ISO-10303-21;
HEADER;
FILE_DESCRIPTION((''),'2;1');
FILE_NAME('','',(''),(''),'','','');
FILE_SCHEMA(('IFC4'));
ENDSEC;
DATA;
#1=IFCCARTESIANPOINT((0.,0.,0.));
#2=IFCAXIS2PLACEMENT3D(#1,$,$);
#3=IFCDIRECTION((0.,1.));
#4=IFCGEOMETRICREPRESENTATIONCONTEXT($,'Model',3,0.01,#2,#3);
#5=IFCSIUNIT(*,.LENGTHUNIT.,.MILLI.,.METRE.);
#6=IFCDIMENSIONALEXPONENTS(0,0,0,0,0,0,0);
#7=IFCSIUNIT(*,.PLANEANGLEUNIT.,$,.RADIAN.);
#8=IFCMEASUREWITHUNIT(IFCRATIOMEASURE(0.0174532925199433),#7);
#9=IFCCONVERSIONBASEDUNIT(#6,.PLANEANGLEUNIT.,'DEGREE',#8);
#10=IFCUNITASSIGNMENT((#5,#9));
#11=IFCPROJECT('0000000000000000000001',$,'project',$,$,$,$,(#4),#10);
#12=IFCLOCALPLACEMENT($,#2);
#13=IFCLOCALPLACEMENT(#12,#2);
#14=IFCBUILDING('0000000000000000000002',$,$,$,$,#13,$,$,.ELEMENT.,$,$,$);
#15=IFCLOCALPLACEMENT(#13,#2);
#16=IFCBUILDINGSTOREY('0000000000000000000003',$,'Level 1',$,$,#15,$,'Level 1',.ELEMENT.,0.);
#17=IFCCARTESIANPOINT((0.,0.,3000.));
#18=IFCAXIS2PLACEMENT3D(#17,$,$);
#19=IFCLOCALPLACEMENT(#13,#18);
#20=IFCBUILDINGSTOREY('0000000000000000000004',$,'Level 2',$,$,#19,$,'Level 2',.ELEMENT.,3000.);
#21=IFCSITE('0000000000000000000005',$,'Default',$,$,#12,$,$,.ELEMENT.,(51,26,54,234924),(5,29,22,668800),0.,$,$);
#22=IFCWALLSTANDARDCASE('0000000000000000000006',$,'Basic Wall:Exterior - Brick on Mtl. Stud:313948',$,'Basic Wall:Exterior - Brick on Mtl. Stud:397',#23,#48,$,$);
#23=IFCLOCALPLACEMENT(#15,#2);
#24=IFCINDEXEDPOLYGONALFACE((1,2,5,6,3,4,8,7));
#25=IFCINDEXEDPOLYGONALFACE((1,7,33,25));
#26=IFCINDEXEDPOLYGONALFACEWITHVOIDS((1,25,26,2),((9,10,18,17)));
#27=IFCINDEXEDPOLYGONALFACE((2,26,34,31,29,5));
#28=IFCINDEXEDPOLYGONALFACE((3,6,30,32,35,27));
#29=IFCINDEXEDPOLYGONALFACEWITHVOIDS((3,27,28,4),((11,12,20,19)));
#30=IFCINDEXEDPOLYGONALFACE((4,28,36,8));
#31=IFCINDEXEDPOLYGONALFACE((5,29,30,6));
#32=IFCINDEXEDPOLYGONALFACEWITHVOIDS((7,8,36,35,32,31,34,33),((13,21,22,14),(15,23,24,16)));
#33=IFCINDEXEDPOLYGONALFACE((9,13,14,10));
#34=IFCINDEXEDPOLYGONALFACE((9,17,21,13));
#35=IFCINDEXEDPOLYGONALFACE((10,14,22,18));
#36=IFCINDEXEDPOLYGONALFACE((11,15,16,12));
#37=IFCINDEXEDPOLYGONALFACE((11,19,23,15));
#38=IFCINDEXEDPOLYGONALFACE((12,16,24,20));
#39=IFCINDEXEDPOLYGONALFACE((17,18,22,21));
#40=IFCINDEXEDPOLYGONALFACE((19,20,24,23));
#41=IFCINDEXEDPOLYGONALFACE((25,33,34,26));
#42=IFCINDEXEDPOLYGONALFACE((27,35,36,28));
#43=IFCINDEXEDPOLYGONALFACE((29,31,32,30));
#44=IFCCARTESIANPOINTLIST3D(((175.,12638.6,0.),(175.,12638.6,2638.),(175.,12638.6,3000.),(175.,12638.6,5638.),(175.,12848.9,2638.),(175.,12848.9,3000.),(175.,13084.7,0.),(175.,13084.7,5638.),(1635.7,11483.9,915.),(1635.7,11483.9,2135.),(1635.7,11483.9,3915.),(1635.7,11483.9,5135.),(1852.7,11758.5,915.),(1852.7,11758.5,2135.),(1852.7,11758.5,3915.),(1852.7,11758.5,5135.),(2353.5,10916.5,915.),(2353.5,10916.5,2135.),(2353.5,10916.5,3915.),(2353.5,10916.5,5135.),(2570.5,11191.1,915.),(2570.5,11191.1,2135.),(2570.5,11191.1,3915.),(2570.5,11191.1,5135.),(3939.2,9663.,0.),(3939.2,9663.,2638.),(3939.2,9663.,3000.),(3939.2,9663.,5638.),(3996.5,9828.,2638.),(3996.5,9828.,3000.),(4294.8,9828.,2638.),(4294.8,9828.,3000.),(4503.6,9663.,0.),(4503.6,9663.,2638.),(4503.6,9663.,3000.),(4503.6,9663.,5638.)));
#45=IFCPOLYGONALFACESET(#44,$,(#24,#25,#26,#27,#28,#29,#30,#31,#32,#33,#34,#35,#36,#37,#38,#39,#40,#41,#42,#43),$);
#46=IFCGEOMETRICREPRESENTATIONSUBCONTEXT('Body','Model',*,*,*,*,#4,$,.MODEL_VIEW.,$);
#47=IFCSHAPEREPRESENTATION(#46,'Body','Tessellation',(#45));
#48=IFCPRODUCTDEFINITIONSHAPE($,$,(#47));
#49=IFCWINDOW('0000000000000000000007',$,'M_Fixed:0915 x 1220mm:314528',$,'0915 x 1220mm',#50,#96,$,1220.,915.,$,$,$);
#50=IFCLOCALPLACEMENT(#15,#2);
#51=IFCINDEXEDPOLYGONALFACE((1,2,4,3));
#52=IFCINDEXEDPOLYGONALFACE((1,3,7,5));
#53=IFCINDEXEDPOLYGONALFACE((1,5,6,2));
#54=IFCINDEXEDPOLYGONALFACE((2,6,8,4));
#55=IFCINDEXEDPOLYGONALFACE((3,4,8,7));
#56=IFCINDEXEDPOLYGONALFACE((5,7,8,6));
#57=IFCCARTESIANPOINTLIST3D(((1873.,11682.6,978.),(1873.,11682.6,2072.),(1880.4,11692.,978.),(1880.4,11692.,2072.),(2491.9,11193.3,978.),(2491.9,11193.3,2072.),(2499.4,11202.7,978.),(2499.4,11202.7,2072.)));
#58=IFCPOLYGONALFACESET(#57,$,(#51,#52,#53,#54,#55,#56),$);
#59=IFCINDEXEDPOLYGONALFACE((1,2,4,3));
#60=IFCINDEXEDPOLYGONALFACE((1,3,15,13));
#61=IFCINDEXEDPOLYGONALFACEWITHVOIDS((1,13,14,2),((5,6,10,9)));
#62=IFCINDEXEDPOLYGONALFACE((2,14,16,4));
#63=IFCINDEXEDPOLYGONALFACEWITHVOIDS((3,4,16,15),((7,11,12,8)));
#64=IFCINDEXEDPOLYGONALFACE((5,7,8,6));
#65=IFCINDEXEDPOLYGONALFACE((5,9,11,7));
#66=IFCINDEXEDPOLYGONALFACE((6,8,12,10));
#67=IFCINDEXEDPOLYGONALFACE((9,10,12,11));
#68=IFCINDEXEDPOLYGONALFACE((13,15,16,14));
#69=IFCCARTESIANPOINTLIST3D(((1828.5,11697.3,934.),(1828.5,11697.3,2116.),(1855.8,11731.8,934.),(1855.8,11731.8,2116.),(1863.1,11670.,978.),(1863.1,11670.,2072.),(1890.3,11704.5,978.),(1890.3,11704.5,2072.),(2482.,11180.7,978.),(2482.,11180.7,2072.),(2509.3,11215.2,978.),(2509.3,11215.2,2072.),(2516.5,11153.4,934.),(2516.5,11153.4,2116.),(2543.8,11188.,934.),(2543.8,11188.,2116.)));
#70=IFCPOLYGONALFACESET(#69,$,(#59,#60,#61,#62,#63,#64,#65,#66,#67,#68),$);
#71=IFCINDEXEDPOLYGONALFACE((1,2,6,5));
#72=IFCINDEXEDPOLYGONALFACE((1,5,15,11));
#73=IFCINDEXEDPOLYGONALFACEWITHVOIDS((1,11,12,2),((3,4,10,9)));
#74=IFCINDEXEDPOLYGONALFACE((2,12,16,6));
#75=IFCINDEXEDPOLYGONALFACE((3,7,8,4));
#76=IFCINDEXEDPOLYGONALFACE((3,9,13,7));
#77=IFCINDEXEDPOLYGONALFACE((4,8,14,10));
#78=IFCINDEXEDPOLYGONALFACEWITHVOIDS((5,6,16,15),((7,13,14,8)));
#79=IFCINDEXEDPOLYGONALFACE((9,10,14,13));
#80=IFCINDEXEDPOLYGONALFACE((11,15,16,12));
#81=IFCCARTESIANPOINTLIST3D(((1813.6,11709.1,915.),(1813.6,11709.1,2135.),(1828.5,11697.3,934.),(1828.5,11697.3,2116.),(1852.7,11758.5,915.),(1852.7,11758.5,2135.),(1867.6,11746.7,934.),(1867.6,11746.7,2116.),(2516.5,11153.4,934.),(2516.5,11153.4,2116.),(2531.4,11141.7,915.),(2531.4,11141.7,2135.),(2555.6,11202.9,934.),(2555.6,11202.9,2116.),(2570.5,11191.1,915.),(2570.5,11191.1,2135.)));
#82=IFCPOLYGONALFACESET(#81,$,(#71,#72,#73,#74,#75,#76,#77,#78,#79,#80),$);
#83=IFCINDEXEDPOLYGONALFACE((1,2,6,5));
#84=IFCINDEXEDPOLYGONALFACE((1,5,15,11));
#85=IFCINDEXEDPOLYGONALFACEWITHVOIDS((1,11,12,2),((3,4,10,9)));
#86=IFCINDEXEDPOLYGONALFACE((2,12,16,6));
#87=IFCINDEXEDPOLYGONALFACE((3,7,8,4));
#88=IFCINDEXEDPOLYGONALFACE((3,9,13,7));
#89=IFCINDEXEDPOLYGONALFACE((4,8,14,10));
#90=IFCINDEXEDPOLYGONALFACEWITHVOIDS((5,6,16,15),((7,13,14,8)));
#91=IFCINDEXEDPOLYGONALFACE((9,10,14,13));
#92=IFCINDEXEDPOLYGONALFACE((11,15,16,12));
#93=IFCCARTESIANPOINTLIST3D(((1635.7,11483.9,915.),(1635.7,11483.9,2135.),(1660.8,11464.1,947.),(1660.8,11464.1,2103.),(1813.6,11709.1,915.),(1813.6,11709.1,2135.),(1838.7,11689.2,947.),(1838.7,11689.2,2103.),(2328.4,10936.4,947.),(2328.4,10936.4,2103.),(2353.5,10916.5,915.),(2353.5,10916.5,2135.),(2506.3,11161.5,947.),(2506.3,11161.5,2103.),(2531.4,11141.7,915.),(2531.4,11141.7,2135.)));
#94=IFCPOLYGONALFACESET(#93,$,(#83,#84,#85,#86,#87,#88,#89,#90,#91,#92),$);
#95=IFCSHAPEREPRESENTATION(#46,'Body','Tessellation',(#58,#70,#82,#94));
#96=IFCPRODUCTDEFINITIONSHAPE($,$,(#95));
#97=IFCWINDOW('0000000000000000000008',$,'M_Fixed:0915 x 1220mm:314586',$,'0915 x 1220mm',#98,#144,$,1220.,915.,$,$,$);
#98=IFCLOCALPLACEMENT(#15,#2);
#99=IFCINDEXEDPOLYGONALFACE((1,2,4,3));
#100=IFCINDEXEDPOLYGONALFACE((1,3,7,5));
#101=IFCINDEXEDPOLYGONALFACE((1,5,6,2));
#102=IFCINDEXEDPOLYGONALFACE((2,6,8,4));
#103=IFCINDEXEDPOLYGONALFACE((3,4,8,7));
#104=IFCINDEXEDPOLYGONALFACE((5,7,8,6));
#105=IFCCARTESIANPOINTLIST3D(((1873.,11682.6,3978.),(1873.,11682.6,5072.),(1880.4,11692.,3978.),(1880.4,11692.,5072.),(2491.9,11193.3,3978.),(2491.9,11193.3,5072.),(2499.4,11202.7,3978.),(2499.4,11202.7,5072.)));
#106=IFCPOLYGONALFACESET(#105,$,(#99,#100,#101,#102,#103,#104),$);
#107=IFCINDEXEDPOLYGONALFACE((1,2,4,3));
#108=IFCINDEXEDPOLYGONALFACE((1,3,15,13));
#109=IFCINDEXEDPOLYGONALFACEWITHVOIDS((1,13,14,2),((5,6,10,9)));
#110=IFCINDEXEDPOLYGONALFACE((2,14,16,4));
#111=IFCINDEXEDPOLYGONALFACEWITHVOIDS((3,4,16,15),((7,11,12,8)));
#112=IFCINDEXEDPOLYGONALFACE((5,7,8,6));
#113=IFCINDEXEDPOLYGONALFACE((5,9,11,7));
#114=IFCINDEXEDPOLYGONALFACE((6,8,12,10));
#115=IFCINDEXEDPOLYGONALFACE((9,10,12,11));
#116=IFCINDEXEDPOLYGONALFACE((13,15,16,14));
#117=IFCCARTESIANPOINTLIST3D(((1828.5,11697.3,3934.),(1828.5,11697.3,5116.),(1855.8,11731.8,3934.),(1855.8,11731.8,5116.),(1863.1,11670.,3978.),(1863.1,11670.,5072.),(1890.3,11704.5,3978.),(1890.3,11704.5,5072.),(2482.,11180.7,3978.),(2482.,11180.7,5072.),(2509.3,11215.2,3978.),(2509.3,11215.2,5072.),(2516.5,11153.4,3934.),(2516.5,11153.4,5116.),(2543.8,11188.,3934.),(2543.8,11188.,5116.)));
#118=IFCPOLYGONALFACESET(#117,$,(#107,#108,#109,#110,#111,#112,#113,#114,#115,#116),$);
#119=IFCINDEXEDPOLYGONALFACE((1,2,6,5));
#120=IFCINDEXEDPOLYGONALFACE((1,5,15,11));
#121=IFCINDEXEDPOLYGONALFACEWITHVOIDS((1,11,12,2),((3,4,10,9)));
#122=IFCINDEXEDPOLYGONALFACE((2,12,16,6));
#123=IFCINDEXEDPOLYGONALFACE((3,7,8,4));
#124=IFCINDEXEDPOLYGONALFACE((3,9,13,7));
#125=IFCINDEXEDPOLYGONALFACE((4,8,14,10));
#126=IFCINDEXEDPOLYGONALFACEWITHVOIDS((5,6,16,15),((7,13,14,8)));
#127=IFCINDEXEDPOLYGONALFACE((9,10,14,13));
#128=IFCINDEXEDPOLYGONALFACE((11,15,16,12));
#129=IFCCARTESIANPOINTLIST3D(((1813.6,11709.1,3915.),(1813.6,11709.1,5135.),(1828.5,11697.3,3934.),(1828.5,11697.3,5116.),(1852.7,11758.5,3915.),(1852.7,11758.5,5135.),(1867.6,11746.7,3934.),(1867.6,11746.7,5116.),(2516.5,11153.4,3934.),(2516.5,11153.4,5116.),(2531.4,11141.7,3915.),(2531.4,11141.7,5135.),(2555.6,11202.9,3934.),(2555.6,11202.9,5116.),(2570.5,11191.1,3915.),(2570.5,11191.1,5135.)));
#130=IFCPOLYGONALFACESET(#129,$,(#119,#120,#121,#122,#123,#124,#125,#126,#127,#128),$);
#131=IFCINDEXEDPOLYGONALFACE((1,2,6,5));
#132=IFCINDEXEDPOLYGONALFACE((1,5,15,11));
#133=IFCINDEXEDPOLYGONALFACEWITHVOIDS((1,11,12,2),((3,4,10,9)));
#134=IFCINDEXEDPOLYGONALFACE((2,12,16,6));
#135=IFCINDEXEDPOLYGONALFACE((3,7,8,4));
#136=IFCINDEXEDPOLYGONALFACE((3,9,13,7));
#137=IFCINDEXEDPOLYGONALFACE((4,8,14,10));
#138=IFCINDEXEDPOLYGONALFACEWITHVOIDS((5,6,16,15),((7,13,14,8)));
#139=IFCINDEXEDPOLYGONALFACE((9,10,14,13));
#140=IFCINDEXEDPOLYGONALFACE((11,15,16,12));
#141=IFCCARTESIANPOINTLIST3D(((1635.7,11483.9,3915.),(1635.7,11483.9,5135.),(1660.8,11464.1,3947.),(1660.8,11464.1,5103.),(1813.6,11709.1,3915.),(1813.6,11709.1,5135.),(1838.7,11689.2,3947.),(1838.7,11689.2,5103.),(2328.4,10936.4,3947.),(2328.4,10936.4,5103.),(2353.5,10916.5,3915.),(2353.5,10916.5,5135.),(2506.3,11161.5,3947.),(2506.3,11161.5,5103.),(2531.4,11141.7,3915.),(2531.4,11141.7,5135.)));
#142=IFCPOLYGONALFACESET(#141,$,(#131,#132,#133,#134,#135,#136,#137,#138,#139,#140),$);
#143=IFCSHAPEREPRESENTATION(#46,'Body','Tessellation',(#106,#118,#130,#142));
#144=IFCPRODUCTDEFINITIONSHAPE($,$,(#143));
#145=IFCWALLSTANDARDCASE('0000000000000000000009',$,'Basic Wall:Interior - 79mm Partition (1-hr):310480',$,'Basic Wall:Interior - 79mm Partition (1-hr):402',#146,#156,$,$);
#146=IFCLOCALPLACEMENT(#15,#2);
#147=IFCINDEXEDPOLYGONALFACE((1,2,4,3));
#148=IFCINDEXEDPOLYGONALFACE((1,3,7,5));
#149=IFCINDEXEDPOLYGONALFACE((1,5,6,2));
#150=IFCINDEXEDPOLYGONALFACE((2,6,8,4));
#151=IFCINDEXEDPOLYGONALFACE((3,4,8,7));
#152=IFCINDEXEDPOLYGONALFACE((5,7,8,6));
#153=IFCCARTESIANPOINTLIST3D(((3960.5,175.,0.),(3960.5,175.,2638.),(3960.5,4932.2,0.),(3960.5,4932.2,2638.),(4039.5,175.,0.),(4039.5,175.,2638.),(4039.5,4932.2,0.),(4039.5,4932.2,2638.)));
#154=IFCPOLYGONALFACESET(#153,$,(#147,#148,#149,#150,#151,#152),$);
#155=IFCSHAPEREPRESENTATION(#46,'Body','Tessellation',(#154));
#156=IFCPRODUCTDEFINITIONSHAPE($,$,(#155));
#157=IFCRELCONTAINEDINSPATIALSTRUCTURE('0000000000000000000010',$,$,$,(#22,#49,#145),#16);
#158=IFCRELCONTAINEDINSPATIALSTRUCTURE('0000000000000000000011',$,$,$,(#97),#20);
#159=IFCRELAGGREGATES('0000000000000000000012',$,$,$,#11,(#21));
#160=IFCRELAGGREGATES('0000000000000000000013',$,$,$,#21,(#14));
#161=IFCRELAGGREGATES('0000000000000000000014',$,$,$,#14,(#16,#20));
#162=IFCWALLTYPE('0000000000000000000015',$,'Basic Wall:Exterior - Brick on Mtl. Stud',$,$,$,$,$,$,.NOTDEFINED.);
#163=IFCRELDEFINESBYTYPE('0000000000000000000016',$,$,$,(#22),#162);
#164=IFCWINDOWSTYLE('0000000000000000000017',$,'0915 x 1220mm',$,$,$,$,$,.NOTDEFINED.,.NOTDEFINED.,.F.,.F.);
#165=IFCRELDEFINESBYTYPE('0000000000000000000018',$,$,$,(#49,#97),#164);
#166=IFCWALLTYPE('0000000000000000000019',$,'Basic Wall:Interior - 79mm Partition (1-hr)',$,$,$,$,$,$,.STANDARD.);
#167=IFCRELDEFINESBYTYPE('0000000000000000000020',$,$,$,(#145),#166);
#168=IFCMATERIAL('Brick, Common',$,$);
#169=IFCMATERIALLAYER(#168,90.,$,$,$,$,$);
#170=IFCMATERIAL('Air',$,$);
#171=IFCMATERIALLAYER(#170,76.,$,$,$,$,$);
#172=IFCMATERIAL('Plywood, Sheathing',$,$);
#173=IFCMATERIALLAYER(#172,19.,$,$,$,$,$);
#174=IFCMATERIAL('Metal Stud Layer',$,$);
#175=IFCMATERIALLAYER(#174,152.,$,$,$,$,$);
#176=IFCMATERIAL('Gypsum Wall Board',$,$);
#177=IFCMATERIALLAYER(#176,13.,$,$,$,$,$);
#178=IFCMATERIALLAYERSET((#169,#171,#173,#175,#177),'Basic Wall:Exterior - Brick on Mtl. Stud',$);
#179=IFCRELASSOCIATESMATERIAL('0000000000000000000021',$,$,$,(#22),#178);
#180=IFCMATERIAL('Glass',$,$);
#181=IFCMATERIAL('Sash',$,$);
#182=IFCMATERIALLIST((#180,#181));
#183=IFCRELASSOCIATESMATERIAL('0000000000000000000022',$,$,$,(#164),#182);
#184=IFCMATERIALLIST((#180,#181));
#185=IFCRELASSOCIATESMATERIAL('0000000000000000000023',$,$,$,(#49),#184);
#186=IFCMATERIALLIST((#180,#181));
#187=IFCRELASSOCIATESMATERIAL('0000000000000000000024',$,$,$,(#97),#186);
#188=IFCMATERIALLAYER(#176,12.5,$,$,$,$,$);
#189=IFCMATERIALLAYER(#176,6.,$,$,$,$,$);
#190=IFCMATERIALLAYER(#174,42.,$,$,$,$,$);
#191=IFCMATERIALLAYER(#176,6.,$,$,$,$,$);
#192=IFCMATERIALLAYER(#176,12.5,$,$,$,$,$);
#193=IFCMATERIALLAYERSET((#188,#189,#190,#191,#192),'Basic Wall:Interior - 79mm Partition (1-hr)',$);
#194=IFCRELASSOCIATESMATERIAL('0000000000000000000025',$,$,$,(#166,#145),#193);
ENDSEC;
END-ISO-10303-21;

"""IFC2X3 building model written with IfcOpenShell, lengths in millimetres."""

from ifc_helpers import new_model, entity, si_unit, converted_unit, direction, frame, frame_2d, origin, place, context, subcontext, project, spatial, polyline, rectangle, outline, extrude, clip, bounded_halfspace, source, transform, mapped, material, material_list, layer, layer_set, layer_usage, type_object, type_shapes, element, fill, save


model = new_model("IFC2X3")

# Units and contexts
model_context = context("Model", 3, precision=0.01, world=origin(), true_north=direction((0.0, 1.0)))
body_context = subcontext(model_context, "Body", "Model", "MODEL_VIEW")
ifc_project = project(units=[si_unit("LENGTHUNIT", "METRE", prefix="MILLI"), converted_unit("PLANEANGLEUNIT", "DEGREE", entity("IfcRatioMeasure", 0.0174532925199433), si_unit("PLANEANGLEUNIT", "RADIAN"), dimensions=[0, 0, 0, 0, 0, 0, 0])], contexts=[model_context])

# Site, building, storey
site_placement = place(None, origin())
site = spatial("IfcSite", under=ifc_project, at=site_placement, Name="Default", CompositionType="ELEMENT", RefLatitude=(51, 26, 54, 234924), RefLongitude=(5, 29, 22, 668800), RefElevation=0.0)
building_placement = place(site_placement, origin())
building = spatial("IfcBuilding", under=site, at=building_placement, CompositionType="ELEMENT")
storey_1_placement = place(building_placement, origin())
storey_1 = spatial("IfcBuildingStorey", under=building, at=storey_1_placement, Name="Level 1", LongName="Level 1", CompositionType="ELEMENT", Elevation=0.0)

# Wall, openings, window
ifc_material_1 = material(Name="Brick, Common")
ifc_layer_1 = layer(ifc_material_1, 90.0)
ifc_material_2 = material(Name="Air")
ifc_layer_2 = layer(ifc_material_2, 76.0)
ifc_material_3 = material(Name="Plywood, Sheathing")
ifc_layer_3 = layer(ifc_material_3, 19.0)
ifc_material_4 = material(Name="Metal Stud Layer")
ifc_layer_4 = layer(ifc_material_4, 152.0)
ifc_material_5 = material(Name="Gypsum Wall Board")
ifc_layer_5 = layer(ifc_material_5, 13.0)
ifc_layer_set_1 = layer_set([ifc_layer_1, ifc_layer_2, ifc_layer_3, ifc_layer_4, ifc_layer_5], Name="Basic Wall:Exterior - Brick on Mtl. Stud")
ifc_layer_usage_1 = layer_usage(ifc_layer_set_1, "AXIS2", "NEGATIVE", 175.0)
wall_type_1 = type_object("IfcWallType", Name="Basic Wall:Exterior - Brick on Mtl. Stud", PredefinedType="NOTDEFINED")
wall_1_placement = place(storey_1_placement, frame((66.5, 12947.5, 0.0), z_axis=(0.0, 0.0, 1.0), x_axis=(0.784491, -0.62014, 0.0)))
wall_1 = element("IfcWallStandardCase", 1, at=wall_1_placement, inside=storey_1, type_object=wall_type_1, material=ifc_layer_usage_1, Name="Basic Wall:Exterior - Brick on Mtl. Stud:313948", ObjectType="Basic Wall:Exterior - Brick on Mtl. Stud:397", context=body_context, shape_type="Clipping", body=[
    clip(extrude(outline(polyline([(5074.9, -175.0), (5517.7, 175.0), (4953.3, 175.0), (0.0, 175.0), (276.7, -175.0), (5074.9, -175.0)])), origin(), (0.0, 0.0, 1.0), 5638.0), bounded_halfspace(frame((4808.9, -175.0, 5638.0), z_axis=(0.0, 0.0, -1.0), x_axis=(0.784491, 0.62014, 0.0)), True, frame((4808.9, -175.0, 5638.0)), polyline([(0.0, 0.0), (266.1, 0.0), (708.8, 350.0), (442.8, 350.0), (208.7, 165.0), (-4662.6, 165.0), (-4532.2, 0.0), (0.0, 0.0)]))),
])
opening_1_placement = place(storey_1_placement, frame((66.5, 12947.5, 0.0), z_axis=(0.0, 0.0, 1.0), x_axis=(0.784491, -0.62014, 0.0)))
element("IfcOpeningElement", 2, at=opening_1_placement, cuts=wall_1, ObjectType="Opening", context=body_context, shape_type="SweptSolid", body=[
    extrude(outline(polyline([(-1447.5, -916.9), (-1656.2, -1081.9), (-1091.8, -1081.9), (2672.4, 1893.7), (2672.4, 2104.0), (-1149.2, -916.9), (-1447.5, -916.9)])), frame((3547.5, -3.3, 2638.0), z_axis=(0.0, 0.0, -1.0), x_axis=(-0.784491, -0.62014, 0.0)), (0.0, 0.0, -1.0), 362.0),
])
opening_2_placement = place(wall_1_placement, frame((2138.6, -175.0, 915.0)))
opening_2 = element("IfcOpeningElement", 3, at=opening_2_placement, cuts=wall_1, ObjectType="Opening", context=body_context, shape_type="SweptSolid", body=[
    extrude(rectangle(XDim=1220.0, YDim=915.0, at=frame_2d((610.0, 457.5), x_axis=(1.0, 0.0))), frame((0.0, 0.0, 0.0), z_axis=(0.0, 1.0, 0.0), x_axis=(0.0, 0.0, 1.0)), (0.0, 0.0, 1.0), 350.0),
])
opening_3_placement = place(wall_1_placement, frame((2138.6, -175.0, 3915.0)))
opening_3 = element("IfcOpeningElement", 4, at=opening_3_placement, cuts=wall_1, ObjectType="Opening", context=body_context, shape_type="SweptSolid", body=[
    extrude(rectangle(XDim=1220.0, YDim=915.0, at=frame_2d((610.0, 457.5), x_axis=(1.0, 0.0))), frame((0.0, 0.0, 0.0), z_axis=(0.0, 1.0, 0.0), x_axis=(0.0, 0.0, 1.0)), (0.0, 0.0, 1.0), 350.0),
])
ifc_material_6 = material(Name="Glass")
ifc_material_7 = material(Name="Sash")
ifc_material_list_1 = material_list([ifc_material_6, ifc_material_7])
ifc_material_list_2 = material_list([ifc_material_6, ifc_material_7])
window_style = type_object("IfcWindowStyle", Name="0915 x 1220mm", ConstructionType="NOTDEFINED", OperationType="NOTDEFINED", ParameterTakesPrecedence=False, Sizeable=False, material=ifc_material_list_2)
shared_shape = source(origin(), body_context, "Body", "SweptSolid", [
    extrude(rectangle(XDim=12.0, YDim=789.0, at=frame_2d((0.0, 0.0), x_axis=(1.0, 0.0))), frame((457.5, 309.0, 63.0), z_axis=(0.0, 0.0, 1.0), x_axis=(0.0, -1.0, 0.0)), (0.0, 0.0, 1.0), 1094.0),
    extrude(outline(polyline([(-438.5, -591.0), (438.5, -591.0), (438.5, 591.0), (-438.5, 591.0), (-438.5, -591.0)]), holes=[polyline([(-394.5, -547.0), (-394.5, 547.0), (394.5, 547.0), (394.5, -547.0), (-394.5, -547.0)])]), frame((457.5, 287.0, 610.0), z_axis=(0.0, 1.0, 0.0), x_axis=(1.0, 0.0, 0.0)), (0.0, 0.0, 1.0), 44.0),
    extrude(outline(polyline([(-457.5, -610.0), (457.5, -610.0), (457.5, 610.0), (-457.5, 610.0), (-457.5, -610.0)]), holes=[polyline([(-438.5, -591.0), (-438.5, 591.0), (438.5, 591.0), (438.5, -591.0), (-438.5, -591.0)])]), frame((457.5, 287.0, 610.0), z_axis=(0.0, 1.0, 0.0), x_axis=(1.0, 0.0, 0.0)), (0.0, 0.0, 1.0), 63.0),
    extrude(outline(polyline([(-457.5, -610.0), (457.5, -610.0), (457.5, 610.0), (-457.5, 610.0), (-457.5, -610.0)]), holes=[polyline([(-425.5, -578.0), (-425.5, 578.0), (425.5, 578.0), (425.5, -578.0), (-425.5, -578.0)])]), frame((457.5, 0.0, 610.0), z_axis=(0.0, 1.0, 0.0), x_axis=(1.0, 0.0, 0.0)), (0.0, 0.0, 1.0), 287.0),
])
type_shapes(window_style, [shared_shape])
window_1_placement = place(opening_2_placement, origin())
window_1 = element("IfcWindow", 5, at=window_1_placement, inside=storey_1, type_object=window_style, material=ifc_material_list_1, Name="M_Fixed:0915 x 1220mm:314528", ObjectType="0915 x 1220mm", OverallHeight=1220.0, OverallWidth=915.0, context=body_context, shape_type="MappedRepresentation", body=[
    mapped(shared_shape, transform((0.0, 0.0, 0.0), scale=1.0)),
])
fill(opening_2, window_1)

# Shared definitions
storey_2_placement = place(building_placement, frame((0.0, 0.0, 3000.0)))
storey_2 = spatial("IfcBuildingStorey", under=building, at=storey_2_placement, Name="Level 2", LongName="Level 2", CompositionType="ELEMENT", Elevation=3000.0)

# Window
ifc_material_list_3 = material_list([ifc_material_6, ifc_material_7])
window_2_placement = place(opening_3_placement, origin())
window_2 = element("IfcWindow", 6, at=window_2_placement, inside=storey_2, type_object=window_style, material=ifc_material_list_3, Name="M_Fixed:0915 x 1220mm:314586", ObjectType="0915 x 1220mm", OverallHeight=1220.0, OverallWidth=915.0, context=body_context, shape_type="MappedRepresentation", body=[
    mapped(shared_shape, transform((0.0, 0.0, 0.0), scale=1.0)),
])
fill(opening_3, window_2)

# Wall
ifc_layer_6 = layer(ifc_material_5, 12.5)
ifc_layer_7 = layer(ifc_material_5, 6.0)
ifc_layer_8 = layer(ifc_material_4, 42.0)
ifc_layer_9 = layer(ifc_material_5, 6.0)
ifc_layer_10 = layer(ifc_material_5, 12.5)
ifc_layer_set_2 = layer_set([ifc_layer_6, ifc_layer_7, ifc_layer_8, ifc_layer_9, ifc_layer_10], Name="Basic Wall:Interior - 79mm Partition (1-hr)")
ifc_layer_usage_2 = layer_usage(ifc_layer_set_2, "AXIS2", "NEGATIVE", 39.5)
wall_type_2 = type_object("IfcWallType", Name="Basic Wall:Interior - 79mm Partition (1-hr)", PredefinedType="STANDARD", material=ifc_layer_set_2)
wall_2_placement = place(storey_1_placement, frame((4000.0, 175.0, 0.0), z_axis=(0.0, 0.0, 1.0), x_axis=(0.0, 1.0, 0.0)))
element("IfcWallStandardCase", 7, at=wall_2_placement, inside=storey_1, type_object=wall_type_2, material=ifc_layer_usage_2, Name="Basic Wall:Interior - 79mm Partition (1-hr):310480", ObjectType="Basic Wall:Interior - 79mm Partition (1-hr):402", context=body_context, shape_type="Clipping", body=[
    clip(extrude(rectangle(XDim=4757.2, YDim=79.0, at=frame_2d((2378.6, 0.0), x_axis=(-1.0, 0.0))), origin(), (0.0, 0.0, 1.0), 2638.0), bounded_halfspace(frame((0.0, -39.5, 2638.0), z_axis=(0.0, 0.0, -1.0), x_axis=(0.0, 1.0, 0.0)), True, frame((0.0, -39.5, 2638.0)), polyline([(0.0, 0.0), (4757.2, 0.0), (4757.2, 79.0), (0.0, 79.0), (0.0, 0.0)]))),
])

save(model, "model.ifc")
